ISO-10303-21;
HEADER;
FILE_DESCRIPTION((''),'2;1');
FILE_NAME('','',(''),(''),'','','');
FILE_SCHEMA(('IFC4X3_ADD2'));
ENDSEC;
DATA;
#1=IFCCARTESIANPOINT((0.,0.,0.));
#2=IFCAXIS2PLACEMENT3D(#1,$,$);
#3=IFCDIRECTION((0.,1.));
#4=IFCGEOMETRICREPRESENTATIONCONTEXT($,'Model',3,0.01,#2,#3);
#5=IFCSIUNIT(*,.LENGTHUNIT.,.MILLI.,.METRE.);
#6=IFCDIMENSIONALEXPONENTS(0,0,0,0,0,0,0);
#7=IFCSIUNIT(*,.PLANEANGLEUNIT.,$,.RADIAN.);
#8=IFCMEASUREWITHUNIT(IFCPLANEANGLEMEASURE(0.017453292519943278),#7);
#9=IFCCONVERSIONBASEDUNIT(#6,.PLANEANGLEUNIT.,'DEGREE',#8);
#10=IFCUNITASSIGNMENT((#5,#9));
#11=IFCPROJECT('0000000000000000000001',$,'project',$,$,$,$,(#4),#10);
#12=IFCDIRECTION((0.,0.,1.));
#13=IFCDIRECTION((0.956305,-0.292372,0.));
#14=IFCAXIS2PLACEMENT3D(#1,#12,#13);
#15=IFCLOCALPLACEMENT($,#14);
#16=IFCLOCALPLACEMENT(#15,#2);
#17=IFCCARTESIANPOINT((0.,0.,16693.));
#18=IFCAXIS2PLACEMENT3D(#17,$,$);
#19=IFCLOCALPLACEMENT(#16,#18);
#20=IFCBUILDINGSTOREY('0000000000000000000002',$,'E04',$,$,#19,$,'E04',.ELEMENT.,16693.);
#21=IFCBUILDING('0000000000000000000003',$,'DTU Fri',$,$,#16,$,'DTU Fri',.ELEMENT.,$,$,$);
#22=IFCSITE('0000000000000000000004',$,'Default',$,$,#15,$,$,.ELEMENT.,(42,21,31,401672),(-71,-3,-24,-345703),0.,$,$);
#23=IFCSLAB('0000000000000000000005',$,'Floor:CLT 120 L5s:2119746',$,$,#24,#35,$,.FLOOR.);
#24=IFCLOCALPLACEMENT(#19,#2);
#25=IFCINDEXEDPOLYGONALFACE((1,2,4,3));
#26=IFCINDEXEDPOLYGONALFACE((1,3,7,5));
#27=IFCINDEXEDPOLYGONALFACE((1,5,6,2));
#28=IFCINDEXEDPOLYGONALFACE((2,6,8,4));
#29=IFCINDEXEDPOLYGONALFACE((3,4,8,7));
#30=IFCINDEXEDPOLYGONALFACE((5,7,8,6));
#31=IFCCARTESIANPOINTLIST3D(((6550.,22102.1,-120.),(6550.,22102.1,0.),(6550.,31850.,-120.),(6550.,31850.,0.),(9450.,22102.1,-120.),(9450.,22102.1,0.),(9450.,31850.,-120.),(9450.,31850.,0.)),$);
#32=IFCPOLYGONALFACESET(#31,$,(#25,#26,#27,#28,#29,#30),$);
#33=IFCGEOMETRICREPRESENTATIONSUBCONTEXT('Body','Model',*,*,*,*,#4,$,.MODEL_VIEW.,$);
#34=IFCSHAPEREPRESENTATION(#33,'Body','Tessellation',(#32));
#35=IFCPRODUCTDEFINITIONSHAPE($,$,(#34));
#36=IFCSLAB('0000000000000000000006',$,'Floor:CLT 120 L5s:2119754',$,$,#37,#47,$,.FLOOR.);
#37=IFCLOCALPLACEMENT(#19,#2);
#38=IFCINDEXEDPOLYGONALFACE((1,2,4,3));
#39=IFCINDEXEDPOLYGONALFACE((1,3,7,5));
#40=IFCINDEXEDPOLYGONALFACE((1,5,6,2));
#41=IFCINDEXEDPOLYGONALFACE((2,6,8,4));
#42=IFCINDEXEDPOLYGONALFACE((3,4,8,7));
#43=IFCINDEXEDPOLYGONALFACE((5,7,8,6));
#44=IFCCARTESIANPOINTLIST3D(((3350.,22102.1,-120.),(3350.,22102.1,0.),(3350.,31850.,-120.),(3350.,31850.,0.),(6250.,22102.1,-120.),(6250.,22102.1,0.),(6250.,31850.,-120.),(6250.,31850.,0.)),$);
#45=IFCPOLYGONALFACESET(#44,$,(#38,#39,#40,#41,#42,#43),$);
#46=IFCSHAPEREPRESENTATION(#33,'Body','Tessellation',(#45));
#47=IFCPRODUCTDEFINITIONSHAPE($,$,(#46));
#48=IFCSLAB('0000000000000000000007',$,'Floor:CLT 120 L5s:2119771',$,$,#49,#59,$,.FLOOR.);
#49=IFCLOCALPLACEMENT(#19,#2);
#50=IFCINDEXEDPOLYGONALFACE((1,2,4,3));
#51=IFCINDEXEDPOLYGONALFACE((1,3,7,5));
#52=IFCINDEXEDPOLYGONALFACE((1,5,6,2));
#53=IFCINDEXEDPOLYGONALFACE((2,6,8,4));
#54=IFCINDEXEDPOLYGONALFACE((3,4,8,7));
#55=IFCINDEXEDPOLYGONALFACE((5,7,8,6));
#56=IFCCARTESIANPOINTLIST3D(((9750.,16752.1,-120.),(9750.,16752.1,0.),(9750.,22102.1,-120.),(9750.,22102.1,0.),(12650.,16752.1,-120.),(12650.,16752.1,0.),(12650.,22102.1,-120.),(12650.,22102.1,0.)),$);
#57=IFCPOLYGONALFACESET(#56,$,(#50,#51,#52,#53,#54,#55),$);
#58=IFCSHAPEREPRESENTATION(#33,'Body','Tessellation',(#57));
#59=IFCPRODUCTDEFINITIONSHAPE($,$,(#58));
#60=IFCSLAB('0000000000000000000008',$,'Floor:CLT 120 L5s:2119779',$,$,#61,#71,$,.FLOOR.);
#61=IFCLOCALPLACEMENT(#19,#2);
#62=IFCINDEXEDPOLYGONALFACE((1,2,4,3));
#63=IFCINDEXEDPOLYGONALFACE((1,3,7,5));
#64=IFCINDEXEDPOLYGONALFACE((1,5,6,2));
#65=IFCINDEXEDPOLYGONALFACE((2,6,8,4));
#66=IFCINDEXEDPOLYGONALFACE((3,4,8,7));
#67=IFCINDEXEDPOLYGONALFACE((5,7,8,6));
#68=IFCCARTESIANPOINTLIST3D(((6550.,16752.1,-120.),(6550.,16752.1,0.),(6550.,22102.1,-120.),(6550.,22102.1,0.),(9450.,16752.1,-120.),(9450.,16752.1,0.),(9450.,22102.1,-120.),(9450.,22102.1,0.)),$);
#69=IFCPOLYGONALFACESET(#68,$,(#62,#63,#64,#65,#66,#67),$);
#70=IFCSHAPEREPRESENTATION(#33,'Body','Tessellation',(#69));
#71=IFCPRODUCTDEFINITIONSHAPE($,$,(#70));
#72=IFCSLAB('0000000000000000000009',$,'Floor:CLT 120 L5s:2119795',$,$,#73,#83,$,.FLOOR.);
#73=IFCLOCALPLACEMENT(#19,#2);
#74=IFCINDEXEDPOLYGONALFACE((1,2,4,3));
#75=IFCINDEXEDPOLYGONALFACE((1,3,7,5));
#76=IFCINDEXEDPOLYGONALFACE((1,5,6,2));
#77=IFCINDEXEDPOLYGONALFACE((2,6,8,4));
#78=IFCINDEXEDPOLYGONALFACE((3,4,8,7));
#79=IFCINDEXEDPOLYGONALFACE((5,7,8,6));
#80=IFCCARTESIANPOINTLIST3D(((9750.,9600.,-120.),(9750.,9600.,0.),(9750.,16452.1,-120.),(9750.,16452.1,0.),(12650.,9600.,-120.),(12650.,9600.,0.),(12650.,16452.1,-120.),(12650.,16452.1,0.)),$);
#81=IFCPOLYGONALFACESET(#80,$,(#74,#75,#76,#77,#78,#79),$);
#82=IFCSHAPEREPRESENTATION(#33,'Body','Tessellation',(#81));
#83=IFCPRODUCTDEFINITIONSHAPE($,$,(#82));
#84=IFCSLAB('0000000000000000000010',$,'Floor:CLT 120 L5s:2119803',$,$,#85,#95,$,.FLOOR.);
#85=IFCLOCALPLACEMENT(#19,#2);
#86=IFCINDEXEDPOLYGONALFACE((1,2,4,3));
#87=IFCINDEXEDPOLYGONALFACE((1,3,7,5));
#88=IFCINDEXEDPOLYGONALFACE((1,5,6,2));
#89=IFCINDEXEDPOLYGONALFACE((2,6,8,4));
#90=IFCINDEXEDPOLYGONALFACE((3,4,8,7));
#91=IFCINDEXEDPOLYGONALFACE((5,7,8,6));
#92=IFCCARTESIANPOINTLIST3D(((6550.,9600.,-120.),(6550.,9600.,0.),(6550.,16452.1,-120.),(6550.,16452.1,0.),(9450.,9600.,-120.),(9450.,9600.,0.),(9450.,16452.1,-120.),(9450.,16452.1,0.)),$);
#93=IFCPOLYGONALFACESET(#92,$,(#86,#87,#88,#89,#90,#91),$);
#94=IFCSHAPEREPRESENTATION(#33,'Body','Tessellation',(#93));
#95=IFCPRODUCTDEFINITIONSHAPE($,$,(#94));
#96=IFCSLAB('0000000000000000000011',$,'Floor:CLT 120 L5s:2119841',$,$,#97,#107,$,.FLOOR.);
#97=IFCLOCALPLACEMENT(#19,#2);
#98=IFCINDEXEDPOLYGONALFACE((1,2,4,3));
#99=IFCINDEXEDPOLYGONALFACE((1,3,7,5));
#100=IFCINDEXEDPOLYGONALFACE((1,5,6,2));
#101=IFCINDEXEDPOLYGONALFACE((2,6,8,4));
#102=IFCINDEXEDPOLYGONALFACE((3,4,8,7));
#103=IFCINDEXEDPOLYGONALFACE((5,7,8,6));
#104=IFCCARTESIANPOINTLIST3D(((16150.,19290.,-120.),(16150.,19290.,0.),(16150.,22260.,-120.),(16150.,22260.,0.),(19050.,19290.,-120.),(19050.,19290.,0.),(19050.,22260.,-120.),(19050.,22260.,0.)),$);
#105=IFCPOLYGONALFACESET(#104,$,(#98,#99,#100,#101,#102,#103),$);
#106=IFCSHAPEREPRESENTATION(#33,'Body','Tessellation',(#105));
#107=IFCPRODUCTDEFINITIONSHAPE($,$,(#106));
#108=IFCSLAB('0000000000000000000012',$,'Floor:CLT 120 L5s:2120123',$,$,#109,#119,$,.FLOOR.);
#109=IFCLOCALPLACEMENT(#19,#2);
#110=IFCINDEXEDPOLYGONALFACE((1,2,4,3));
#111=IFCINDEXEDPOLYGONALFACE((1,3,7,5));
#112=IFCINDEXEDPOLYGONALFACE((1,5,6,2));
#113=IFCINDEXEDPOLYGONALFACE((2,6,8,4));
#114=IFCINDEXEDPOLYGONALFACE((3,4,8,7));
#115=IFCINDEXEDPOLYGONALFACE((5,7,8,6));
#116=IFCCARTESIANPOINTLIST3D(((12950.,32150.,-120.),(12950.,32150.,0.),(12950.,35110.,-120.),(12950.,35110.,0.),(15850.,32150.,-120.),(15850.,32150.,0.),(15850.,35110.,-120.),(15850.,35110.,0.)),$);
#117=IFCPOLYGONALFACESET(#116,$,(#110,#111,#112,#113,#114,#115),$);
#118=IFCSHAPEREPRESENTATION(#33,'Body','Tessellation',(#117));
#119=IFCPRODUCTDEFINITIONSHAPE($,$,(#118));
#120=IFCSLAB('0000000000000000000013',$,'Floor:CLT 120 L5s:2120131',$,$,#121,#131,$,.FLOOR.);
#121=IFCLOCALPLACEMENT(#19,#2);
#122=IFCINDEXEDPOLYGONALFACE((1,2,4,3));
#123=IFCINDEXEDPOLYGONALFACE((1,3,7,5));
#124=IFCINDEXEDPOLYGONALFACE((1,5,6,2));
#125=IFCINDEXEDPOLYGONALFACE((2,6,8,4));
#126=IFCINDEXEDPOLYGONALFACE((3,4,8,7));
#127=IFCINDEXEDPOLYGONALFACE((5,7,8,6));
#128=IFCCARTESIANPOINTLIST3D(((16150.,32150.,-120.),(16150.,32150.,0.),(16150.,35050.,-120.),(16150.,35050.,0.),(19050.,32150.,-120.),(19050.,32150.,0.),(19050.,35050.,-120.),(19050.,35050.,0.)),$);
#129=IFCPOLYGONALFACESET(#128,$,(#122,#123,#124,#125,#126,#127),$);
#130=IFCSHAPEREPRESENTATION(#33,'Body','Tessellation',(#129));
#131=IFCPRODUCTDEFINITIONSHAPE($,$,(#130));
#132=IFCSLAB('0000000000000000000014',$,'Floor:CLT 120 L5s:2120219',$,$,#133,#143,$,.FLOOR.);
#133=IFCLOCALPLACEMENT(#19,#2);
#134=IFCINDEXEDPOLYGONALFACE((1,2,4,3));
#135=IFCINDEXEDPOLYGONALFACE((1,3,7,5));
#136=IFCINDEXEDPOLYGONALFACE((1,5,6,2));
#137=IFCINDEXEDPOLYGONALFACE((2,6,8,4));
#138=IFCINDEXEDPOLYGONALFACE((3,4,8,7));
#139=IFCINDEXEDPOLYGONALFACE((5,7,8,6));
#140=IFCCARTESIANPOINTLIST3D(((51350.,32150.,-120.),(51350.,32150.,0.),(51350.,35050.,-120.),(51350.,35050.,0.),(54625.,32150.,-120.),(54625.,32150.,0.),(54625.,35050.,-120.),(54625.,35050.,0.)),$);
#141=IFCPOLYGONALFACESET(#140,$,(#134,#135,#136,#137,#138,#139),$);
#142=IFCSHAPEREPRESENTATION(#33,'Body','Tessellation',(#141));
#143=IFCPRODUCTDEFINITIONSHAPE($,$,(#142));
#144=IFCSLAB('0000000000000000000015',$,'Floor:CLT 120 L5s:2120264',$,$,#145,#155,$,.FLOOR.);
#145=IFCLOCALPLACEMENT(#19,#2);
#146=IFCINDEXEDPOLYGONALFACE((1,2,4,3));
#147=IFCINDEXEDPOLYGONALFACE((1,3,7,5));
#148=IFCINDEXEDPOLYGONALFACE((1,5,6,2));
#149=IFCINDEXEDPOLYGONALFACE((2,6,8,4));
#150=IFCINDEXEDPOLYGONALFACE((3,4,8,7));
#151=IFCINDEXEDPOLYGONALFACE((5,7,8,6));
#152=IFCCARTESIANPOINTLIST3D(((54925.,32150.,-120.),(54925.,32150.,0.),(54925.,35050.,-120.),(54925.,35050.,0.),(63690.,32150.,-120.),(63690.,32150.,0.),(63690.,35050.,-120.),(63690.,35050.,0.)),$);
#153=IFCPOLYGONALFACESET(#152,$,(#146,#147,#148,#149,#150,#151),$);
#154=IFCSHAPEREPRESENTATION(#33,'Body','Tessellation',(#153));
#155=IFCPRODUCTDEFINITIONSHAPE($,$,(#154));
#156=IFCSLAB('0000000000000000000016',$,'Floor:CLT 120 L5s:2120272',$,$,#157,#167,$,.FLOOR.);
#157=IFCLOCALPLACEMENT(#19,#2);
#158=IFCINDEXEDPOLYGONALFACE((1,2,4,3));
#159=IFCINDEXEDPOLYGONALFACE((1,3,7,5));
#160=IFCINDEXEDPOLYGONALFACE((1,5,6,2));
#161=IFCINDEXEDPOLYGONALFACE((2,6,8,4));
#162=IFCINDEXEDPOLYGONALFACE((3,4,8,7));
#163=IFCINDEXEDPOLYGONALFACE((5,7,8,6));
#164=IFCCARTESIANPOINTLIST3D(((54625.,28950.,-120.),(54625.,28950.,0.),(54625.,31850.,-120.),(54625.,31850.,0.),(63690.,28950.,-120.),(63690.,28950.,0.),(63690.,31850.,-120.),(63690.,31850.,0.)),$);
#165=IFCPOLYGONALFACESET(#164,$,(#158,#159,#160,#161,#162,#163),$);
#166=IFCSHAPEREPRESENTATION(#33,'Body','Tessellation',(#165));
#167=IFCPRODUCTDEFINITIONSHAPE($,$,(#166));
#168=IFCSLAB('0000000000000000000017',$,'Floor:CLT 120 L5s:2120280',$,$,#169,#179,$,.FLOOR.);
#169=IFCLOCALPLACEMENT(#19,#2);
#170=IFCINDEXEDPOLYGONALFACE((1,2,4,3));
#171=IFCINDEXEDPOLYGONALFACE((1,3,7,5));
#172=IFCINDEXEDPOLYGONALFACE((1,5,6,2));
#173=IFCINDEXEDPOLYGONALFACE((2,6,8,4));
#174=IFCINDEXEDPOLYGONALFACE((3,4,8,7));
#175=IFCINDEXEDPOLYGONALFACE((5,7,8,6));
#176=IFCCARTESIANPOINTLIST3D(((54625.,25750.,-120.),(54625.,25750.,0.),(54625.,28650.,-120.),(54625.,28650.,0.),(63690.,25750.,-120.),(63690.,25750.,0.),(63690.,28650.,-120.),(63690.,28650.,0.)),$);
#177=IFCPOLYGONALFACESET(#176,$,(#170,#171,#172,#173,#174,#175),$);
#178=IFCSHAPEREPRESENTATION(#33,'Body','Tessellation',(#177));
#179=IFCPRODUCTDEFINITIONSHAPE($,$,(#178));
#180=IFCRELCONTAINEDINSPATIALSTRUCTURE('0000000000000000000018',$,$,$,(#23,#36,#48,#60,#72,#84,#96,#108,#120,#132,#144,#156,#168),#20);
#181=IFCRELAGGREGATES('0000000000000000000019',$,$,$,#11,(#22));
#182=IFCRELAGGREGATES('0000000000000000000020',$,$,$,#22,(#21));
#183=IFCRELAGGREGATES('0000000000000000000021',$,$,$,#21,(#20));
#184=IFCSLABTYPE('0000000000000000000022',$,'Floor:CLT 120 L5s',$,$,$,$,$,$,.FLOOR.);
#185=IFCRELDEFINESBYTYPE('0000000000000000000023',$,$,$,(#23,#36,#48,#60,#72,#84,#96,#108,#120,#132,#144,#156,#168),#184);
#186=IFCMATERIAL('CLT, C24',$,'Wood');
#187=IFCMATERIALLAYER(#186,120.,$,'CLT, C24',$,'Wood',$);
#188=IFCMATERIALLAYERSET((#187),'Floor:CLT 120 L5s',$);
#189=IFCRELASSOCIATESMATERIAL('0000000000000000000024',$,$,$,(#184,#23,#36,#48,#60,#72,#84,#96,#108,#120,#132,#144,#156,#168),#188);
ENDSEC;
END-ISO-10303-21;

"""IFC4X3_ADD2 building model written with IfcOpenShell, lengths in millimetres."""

from ifc_helpers import new_model, entity, si_unit, converted_unit, direction, frame, frame_2d, origin, place, context, subcontext, project, spatial, rectangle, extrude, material, layer, layer_set, layer_usage, type_object, element, save


model = new_model("IFC4X3_ADD2")

# Units and contexts
model_context = context("Model", 3, precision=0.01, world=origin(), true_north=direction((0.0, 1.0)))
body_context = subcontext(model_context, "Body", "Model", "MODEL_VIEW")
ifc_project = project(units=[si_unit("LENGTHUNIT", "METRE", prefix="MILLI"), converted_unit("PLANEANGLEUNIT", "DEGREE", entity("IfcPlaneAngleMeasure", 0.017453292519943278), si_unit("PLANEANGLEUNIT", "RADIAN"), dimensions=[0, 0, 0, 0, 0, 0, 0])], contexts=[model_context])

# Site, building, storey
site_placement = place(None, frame((0.0, 0.0, 0.0), z_axis=(0.0, 0.0, 1.0), x_axis=(0.956305, -0.292372, 0.0)))
site = spatial("IfcSite", under=ifc_project, at=site_placement, Name="Default", CompositionType="ELEMENT", RefLatitude=(42, 21, 31, 401672), RefLongitude=(-71, -3, -24, -345703), RefElevation=0.0)
building_placement = place(site_placement, origin())
building = spatial("IfcBuilding", under=site, at=building_placement, Name="DTU Fri", LongName="DTU Fri", CompositionType="ELEMENT")
storey_placement = place(building_placement, frame((0.0, 0.0, 16693.0)))
storey = spatial("IfcBuildingStorey", under=building, at=storey_placement, Name="E04", LongName="E04", CompositionType="ELEMENT", Elevation=16693.0)

# Slabs
ifc_material = material(Name="CLT, C24", Category="Wood")
ifc_layer = layer(ifc_material, 120.0, Name="CLT, C24", Category="Wood")
ifc_layer_set = layer_set([ifc_layer], Name="Floor:CLT 120 L5s")
slab_type = type_object("IfcSlabType", Name="Floor:CLT 120 L5s", PredefinedType="FLOOR", material=ifc_layer_set)
ifc_layer_usage_1 = layer_usage(ifc_layer_set, "AXIS3", "POSITIVE", 0.0)
slab_1_placement = place(storey_placement, origin())
element("IfcSlab", 1, at=slab_1_placement, inside=storey, type_object=slab_type, material=ifc_layer_usage_1, Name="Floor:CLT 120 L5s:2119746", PredefinedType="FLOOR", context=body_context, shape_type="SweptSolid", body=[
    extrude(rectangle(XDim=9747.9, YDim=2900.0, at=frame_2d((0.0, 0.0), x_axis=(1.0, 0.0))), frame((8000.0, 26976.0, 0.0), z_axis=(0.0, 0.0, -1.0), x_axis=(0.0, 1.0, 0.0)), (0.0, 0.0, 1.0), 120.0),
])
ifc_layer_usage_2 = layer_usage(ifc_layer_set, "AXIS3", "POSITIVE", 0.0)
slab_2_placement = place(storey_placement, origin())
element("IfcSlab", 2, at=slab_2_placement, inside=storey, type_object=slab_type, material=ifc_layer_usage_2, Name="Floor:CLT 120 L5s:2119754", PredefinedType="FLOOR", context=body_context, shape_type="SweptSolid", body=[
    extrude(rectangle(XDim=9747.9, YDim=2900.0, at=frame_2d((0.0, 0.0), x_axis=(1.0, 0.0))), frame((4800.0, 26976.0, 0.0), z_axis=(0.0, 0.0, -1.0), x_axis=(0.0, 1.0, 0.0)), (0.0, 0.0, 1.0), 120.0),
])
ifc_layer_usage_3 = layer_usage(ifc_layer_set, "AXIS3", "POSITIVE", 0.0)
slab_3_placement = place(storey_placement, origin())
element("IfcSlab", 3, at=slab_3_placement, inside=storey, type_object=slab_type, material=ifc_layer_usage_3, Name="Floor:CLT 120 L5s:2119771", PredefinedType="FLOOR", context=body_context, shape_type="SweptSolid", body=[
    extrude(rectangle(XDim=5350.0, YDim=2900.0, at=frame_2d((0.0, 0.0), x_axis=(1.0, 0.0))), frame((11200.0, 19427.1, 0.0), z_axis=(0.0, 0.0, -1.0), x_axis=(0.0, 1.0, 0.0)), (0.0, 0.0, 1.0), 120.0),
])
ifc_layer_usage_4 = layer_usage(ifc_layer_set, "AXIS3", "POSITIVE", 0.0)
slab_4_placement = place(storey_placement, origin())
element("IfcSlab", 4, at=slab_4_placement, inside=storey, type_object=slab_type, material=ifc_layer_usage_4, Name="Floor:CLT 120 L5s:2119779", PredefinedType="FLOOR", context=body_context, shape_type="SweptSolid", body=[
    extrude(rectangle(XDim=5350.0, YDim=2900.0, at=frame_2d((0.0, 0.0), x_axis=(1.0, 0.0))), frame((8000.0, 19427.1, 0.0), z_axis=(0.0, 0.0, -1.0), x_axis=(0.0, 1.0, 0.0)), (0.0, 0.0, 1.0), 120.0),
])
ifc_layer_usage_5 = layer_usage(ifc_layer_set, "AXIS3", "POSITIVE", 0.0)
slab_5_placement = place(storey_placement, origin())
element("IfcSlab", 5, at=slab_5_placement, inside=storey, type_object=slab_type, material=ifc_layer_usage_5, Name="Floor:CLT 120 L5s:2119795", PredefinedType="FLOOR", context=body_context, shape_type="SweptSolid", body=[
    extrude(rectangle(XDim=6852.1, YDim=2900.0, at=frame_2d((0.0, 0.0), x_axis=(1.0, 0.0))), frame((11200.0, 13026.0, 0.0), z_axis=(0.0, 0.0, -1.0), x_axis=(0.0, 1.0, 0.0)), (0.0, 0.0, 1.0), 120.0),
])
ifc_layer_usage_6 = layer_usage(ifc_layer_set, "AXIS3", "POSITIVE", 0.0)
slab_6_placement = place(storey_placement, origin())
element("IfcSlab", 6, at=slab_6_placement, inside=storey, type_object=slab_type, material=ifc_layer_usage_6, Name="Floor:CLT 120 L5s:2119803", PredefinedType="FLOOR", context=body_context, shape_type="SweptSolid", body=[
    extrude(rectangle(XDim=6852.1, YDim=2900.0, at=frame_2d((0.0, 0.0), x_axis=(1.0, 0.0))), frame((8000.0, 13026.0, 0.0), z_axis=(0.0, 0.0, -1.0), x_axis=(0.0, 1.0, 0.0)), (0.0, 0.0, 1.0), 120.0),
])
ifc_layer_usage_7 = layer_usage(ifc_layer_set, "AXIS3", "POSITIVE", 0.0)
slab_7_placement = place(storey_placement, origin())
element("IfcSlab", 7, at=slab_7_placement, inside=storey, type_object=slab_type, material=ifc_layer_usage_7, Name="Floor:CLT 120 L5s:2119841", PredefinedType="FLOOR", context=body_context, shape_type="SweptSolid", body=[
    extrude(rectangle(XDim=2970.0, YDim=2900.0, at=frame_2d((0.0, 0.0), x_axis=(1.0, 0.0))), frame((17600.0, 20775.0, 0.0), z_axis=(0.0, 0.0, -1.0), x_axis=(0.0, 1.0, 0.0)), (0.0, 0.0, 1.0), 120.0),
])
ifc_layer_usage_8 = layer_usage(ifc_layer_set, "AXIS3", "POSITIVE", 0.0)
slab_8_placement = place(storey_placement, origin())
element("IfcSlab", 8, at=slab_8_placement, inside=storey, type_object=slab_type, material=ifc_layer_usage_8, Name="Floor:CLT 120 L5s:2120123", PredefinedType="FLOOR", context=body_context, shape_type="SweptSolid", body=[
    extrude(rectangle(XDim=2960.0, YDim=2900.0, at=frame_2d((0.0, 0.0), x_axis=(1.0, 0.0))), frame((14400.0, 33630.0, 0.0), z_axis=(0.0, 0.0, -1.0), x_axis=(0.0, 1.0, 0.0)), (0.0, 0.0, 1.0), 120.0),
])
ifc_layer_usage_9 = layer_usage(ifc_layer_set, "AXIS3", "POSITIVE", 0.0)
slab_9_placement = place(storey_placement, origin())
element("IfcSlab", 9, at=slab_9_placement, inside=storey, type_object=slab_type, material=ifc_layer_usage_9, Name="Floor:CLT 120 L5s:2120131", PredefinedType="FLOOR", context=body_context, shape_type="SweptSolid", body=[
    extrude(rectangle(XDim=2900.0, YDim=2900.0, at=frame_2d((0.0, 0.0), x_axis=(1.0, 0.0))), frame((17600.0, 33600.0, 0.0), z_axis=(0.0, 0.0, -1.0), x_axis=(0.0, 1.0, 0.0)), (0.0, 0.0, 1.0), 120.0),
])
ifc_layer_usage_10 = layer_usage(ifc_layer_set, "AXIS3", "POSITIVE", 0.0)
slab_10_placement = place(storey_placement, origin())
element("IfcSlab", 10, at=slab_10_placement, inside=storey, type_object=slab_type, material=ifc_layer_usage_10, Name="Floor:CLT 120 L5s:2120219", PredefinedType="FLOOR", context=body_context, shape_type="SweptSolid", body=[
    extrude(rectangle(XDim=2900.0, YDim=3275.0, at=frame_2d((0.0, 0.0), x_axis=(1.0, 0.0))), frame((52987.5, 33600.0, 0.0), z_axis=(0.0, 0.0, -1.0), x_axis=(0.0, 1.0, 0.0)), (0.0, 0.0, 1.0), 120.0),
])
ifc_layer_usage_11 = layer_usage(ifc_layer_set, "AXIS3", "POSITIVE", 0.0)
slab_11_placement = place(storey_placement, origin())
element("IfcSlab", 11, at=slab_11_placement, inside=storey, type_object=slab_type, material=ifc_layer_usage_11, Name="Floor:CLT 120 L5s:2120264", PredefinedType="FLOOR", context=body_context, shape_type="SweptSolid", body=[
    extrude(rectangle(XDim=2900.0, YDim=8765.0, at=frame_2d((0.0, 0.0), x_axis=(1.0, 0.0))), frame((59307.5, 33600.0, 0.0), z_axis=(0.0, 0.0, -1.0), x_axis=(0.0, 1.0, 0.0)), (0.0, 0.0, 1.0), 120.0),
])
ifc_layer_usage_12 = layer_usage(ifc_layer_set, "AXIS3", "POSITIVE", 0.0)
slab_12_placement = place(storey_placement, origin())
element("IfcSlab", 12, at=slab_12_placement, inside=storey, type_object=slab_type, material=ifc_layer_usage_12, Name="Floor:CLT 120 L5s:2120272", PredefinedType="FLOOR", context=body_context, shape_type="SweptSolid", body=[
    extrude(rectangle(XDim=2900.0, YDim=9065.0, at=frame_2d((0.0, 0.0), x_axis=(1.0, 0.0))), frame((59157.5, 30400.0, 0.0), z_axis=(0.0, 0.0, -1.0), x_axis=(0.0, 1.0, 0.0)), (0.0, 0.0, 1.0), 120.0),
])
ifc_layer_usage_13 = layer_usage(ifc_layer_set, "AXIS3", "POSITIVE", 0.0)
slab_13_placement = place(storey_placement, origin())
element("IfcSlab", 13, at=slab_13_placement, inside=storey, type_object=slab_type, material=ifc_layer_usage_13, Name="Floor:CLT 120 L5s:2120280", PredefinedType="FLOOR", context=body_context, shape_type="SweptSolid", body=[
    extrude(rectangle(XDim=2900.0, YDim=9065.0, at=frame_2d((0.0, 0.0), x_axis=(1.0, 0.0))), frame((59157.5, 27200.0, 0.0), z_axis=(0.0, 0.0, -1.0), x_axis=(0.0, 1.0, 0.0)), (0.0, 0.0, 1.0), 120.0),
])

save(model, "model.ifc")
